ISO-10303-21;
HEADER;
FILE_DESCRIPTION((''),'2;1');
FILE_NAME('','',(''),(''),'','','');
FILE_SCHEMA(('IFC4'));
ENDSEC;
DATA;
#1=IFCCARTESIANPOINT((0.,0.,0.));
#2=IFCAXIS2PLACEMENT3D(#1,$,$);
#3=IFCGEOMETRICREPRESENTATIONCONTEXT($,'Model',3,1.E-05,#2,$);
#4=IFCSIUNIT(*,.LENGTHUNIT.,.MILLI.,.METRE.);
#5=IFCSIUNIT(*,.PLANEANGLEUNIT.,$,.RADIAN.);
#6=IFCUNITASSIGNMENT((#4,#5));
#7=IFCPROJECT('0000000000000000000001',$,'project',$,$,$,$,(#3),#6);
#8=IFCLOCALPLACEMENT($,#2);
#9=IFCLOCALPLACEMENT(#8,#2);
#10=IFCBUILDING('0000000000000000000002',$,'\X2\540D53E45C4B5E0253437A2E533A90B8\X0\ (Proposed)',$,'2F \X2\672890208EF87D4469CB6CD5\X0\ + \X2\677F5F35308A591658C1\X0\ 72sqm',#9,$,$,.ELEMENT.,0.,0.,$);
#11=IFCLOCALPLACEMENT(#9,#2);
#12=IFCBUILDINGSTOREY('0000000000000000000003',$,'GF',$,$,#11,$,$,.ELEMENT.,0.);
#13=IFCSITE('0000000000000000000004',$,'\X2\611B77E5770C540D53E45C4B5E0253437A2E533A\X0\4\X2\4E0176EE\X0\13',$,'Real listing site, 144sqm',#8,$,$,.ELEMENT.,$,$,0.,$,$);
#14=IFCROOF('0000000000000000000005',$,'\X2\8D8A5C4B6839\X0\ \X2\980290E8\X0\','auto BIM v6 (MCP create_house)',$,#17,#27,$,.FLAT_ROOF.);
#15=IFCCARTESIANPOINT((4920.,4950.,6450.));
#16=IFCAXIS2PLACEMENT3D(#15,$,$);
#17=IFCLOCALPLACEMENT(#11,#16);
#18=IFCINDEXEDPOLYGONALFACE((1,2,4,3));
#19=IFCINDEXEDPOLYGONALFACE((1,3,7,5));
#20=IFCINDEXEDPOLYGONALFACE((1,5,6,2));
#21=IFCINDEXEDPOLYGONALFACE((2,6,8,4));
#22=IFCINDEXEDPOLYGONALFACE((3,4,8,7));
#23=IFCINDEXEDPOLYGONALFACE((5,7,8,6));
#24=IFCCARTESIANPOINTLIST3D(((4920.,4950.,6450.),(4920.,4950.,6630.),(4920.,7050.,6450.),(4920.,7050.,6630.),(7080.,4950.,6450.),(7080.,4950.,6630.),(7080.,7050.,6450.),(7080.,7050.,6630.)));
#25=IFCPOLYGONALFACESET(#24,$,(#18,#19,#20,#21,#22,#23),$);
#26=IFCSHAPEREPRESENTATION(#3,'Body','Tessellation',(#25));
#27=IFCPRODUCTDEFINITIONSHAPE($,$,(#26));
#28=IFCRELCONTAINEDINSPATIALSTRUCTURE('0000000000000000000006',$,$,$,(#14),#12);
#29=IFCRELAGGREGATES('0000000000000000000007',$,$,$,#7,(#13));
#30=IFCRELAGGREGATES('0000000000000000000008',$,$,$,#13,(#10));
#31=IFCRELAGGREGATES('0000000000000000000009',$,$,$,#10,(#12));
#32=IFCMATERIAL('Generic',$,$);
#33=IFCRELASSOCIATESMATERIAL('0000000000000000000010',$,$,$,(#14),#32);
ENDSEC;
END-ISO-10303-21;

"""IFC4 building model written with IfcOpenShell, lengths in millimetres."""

from ifc_helpers import new_model, si_unit, frame, frame_2d, origin, place, context, project, spatial, rectangle, extrude, material, element, save


model = new_model("IFC4")

# Units and contexts
model_context = context("Model", 3, precision=1e-05, world=origin())
ifc_project = project(units=[si_unit("LENGTHUNIT", "METRE", prefix="MILLI"), si_unit("PLANEANGLEUNIT", "RADIAN")], contexts=[model_context])

# Site, building, storey
site_placement = place(None, origin())
site = spatial("IfcSite", under=ifc_project, at=site_placement, Name="愛知県名古屋市千種区4丁目13", ObjectType="Real listing site, 144sqm", CompositionType="ELEMENT", RefElevation=0.0)
building_placement = place(site_placement, origin())
building = spatial("IfcBuilding", under=site, at=building_placement, Name="名古屋市千種区邸 (Proposed)", ObjectType="2F 木造軸組構法 + 板張り外壁 72sqm", CompositionType="ELEMENT", ElevationOfRefHeight=0.0, ElevationOfTerrain=0.0)
storey_placement = place(building_placement, origin())
storey = spatial("IfcBuildingStorey", under=building, at=storey_placement, Name="GF", CompositionType="ELEMENT", Elevation=0.0)

# Shared definitions
ifc_material = material(Name="Generic")

# Roof
roof_placement = place(storey_placement, frame((4920.0, 4950.0, 6450.0)))
element("IfcRoof", 1, at=roof_placement, inside=storey, material=ifc_material, Name="越屋根 頂部", Description="auto BIM v6 (MCP create_house)", PredefinedType="FLAT_ROOF", context=model_context, shape_type="SweptSolid", body=[
    extrude(rectangle(XDim=2160.0, YDim=2100.0, at=frame_2d((1080.0, 1050.0))), frame((4920.0, 4950.0, 6450.0)), (0.0, 0.0, 1.0), 180.0),
])

save(model, "model.ifc")
